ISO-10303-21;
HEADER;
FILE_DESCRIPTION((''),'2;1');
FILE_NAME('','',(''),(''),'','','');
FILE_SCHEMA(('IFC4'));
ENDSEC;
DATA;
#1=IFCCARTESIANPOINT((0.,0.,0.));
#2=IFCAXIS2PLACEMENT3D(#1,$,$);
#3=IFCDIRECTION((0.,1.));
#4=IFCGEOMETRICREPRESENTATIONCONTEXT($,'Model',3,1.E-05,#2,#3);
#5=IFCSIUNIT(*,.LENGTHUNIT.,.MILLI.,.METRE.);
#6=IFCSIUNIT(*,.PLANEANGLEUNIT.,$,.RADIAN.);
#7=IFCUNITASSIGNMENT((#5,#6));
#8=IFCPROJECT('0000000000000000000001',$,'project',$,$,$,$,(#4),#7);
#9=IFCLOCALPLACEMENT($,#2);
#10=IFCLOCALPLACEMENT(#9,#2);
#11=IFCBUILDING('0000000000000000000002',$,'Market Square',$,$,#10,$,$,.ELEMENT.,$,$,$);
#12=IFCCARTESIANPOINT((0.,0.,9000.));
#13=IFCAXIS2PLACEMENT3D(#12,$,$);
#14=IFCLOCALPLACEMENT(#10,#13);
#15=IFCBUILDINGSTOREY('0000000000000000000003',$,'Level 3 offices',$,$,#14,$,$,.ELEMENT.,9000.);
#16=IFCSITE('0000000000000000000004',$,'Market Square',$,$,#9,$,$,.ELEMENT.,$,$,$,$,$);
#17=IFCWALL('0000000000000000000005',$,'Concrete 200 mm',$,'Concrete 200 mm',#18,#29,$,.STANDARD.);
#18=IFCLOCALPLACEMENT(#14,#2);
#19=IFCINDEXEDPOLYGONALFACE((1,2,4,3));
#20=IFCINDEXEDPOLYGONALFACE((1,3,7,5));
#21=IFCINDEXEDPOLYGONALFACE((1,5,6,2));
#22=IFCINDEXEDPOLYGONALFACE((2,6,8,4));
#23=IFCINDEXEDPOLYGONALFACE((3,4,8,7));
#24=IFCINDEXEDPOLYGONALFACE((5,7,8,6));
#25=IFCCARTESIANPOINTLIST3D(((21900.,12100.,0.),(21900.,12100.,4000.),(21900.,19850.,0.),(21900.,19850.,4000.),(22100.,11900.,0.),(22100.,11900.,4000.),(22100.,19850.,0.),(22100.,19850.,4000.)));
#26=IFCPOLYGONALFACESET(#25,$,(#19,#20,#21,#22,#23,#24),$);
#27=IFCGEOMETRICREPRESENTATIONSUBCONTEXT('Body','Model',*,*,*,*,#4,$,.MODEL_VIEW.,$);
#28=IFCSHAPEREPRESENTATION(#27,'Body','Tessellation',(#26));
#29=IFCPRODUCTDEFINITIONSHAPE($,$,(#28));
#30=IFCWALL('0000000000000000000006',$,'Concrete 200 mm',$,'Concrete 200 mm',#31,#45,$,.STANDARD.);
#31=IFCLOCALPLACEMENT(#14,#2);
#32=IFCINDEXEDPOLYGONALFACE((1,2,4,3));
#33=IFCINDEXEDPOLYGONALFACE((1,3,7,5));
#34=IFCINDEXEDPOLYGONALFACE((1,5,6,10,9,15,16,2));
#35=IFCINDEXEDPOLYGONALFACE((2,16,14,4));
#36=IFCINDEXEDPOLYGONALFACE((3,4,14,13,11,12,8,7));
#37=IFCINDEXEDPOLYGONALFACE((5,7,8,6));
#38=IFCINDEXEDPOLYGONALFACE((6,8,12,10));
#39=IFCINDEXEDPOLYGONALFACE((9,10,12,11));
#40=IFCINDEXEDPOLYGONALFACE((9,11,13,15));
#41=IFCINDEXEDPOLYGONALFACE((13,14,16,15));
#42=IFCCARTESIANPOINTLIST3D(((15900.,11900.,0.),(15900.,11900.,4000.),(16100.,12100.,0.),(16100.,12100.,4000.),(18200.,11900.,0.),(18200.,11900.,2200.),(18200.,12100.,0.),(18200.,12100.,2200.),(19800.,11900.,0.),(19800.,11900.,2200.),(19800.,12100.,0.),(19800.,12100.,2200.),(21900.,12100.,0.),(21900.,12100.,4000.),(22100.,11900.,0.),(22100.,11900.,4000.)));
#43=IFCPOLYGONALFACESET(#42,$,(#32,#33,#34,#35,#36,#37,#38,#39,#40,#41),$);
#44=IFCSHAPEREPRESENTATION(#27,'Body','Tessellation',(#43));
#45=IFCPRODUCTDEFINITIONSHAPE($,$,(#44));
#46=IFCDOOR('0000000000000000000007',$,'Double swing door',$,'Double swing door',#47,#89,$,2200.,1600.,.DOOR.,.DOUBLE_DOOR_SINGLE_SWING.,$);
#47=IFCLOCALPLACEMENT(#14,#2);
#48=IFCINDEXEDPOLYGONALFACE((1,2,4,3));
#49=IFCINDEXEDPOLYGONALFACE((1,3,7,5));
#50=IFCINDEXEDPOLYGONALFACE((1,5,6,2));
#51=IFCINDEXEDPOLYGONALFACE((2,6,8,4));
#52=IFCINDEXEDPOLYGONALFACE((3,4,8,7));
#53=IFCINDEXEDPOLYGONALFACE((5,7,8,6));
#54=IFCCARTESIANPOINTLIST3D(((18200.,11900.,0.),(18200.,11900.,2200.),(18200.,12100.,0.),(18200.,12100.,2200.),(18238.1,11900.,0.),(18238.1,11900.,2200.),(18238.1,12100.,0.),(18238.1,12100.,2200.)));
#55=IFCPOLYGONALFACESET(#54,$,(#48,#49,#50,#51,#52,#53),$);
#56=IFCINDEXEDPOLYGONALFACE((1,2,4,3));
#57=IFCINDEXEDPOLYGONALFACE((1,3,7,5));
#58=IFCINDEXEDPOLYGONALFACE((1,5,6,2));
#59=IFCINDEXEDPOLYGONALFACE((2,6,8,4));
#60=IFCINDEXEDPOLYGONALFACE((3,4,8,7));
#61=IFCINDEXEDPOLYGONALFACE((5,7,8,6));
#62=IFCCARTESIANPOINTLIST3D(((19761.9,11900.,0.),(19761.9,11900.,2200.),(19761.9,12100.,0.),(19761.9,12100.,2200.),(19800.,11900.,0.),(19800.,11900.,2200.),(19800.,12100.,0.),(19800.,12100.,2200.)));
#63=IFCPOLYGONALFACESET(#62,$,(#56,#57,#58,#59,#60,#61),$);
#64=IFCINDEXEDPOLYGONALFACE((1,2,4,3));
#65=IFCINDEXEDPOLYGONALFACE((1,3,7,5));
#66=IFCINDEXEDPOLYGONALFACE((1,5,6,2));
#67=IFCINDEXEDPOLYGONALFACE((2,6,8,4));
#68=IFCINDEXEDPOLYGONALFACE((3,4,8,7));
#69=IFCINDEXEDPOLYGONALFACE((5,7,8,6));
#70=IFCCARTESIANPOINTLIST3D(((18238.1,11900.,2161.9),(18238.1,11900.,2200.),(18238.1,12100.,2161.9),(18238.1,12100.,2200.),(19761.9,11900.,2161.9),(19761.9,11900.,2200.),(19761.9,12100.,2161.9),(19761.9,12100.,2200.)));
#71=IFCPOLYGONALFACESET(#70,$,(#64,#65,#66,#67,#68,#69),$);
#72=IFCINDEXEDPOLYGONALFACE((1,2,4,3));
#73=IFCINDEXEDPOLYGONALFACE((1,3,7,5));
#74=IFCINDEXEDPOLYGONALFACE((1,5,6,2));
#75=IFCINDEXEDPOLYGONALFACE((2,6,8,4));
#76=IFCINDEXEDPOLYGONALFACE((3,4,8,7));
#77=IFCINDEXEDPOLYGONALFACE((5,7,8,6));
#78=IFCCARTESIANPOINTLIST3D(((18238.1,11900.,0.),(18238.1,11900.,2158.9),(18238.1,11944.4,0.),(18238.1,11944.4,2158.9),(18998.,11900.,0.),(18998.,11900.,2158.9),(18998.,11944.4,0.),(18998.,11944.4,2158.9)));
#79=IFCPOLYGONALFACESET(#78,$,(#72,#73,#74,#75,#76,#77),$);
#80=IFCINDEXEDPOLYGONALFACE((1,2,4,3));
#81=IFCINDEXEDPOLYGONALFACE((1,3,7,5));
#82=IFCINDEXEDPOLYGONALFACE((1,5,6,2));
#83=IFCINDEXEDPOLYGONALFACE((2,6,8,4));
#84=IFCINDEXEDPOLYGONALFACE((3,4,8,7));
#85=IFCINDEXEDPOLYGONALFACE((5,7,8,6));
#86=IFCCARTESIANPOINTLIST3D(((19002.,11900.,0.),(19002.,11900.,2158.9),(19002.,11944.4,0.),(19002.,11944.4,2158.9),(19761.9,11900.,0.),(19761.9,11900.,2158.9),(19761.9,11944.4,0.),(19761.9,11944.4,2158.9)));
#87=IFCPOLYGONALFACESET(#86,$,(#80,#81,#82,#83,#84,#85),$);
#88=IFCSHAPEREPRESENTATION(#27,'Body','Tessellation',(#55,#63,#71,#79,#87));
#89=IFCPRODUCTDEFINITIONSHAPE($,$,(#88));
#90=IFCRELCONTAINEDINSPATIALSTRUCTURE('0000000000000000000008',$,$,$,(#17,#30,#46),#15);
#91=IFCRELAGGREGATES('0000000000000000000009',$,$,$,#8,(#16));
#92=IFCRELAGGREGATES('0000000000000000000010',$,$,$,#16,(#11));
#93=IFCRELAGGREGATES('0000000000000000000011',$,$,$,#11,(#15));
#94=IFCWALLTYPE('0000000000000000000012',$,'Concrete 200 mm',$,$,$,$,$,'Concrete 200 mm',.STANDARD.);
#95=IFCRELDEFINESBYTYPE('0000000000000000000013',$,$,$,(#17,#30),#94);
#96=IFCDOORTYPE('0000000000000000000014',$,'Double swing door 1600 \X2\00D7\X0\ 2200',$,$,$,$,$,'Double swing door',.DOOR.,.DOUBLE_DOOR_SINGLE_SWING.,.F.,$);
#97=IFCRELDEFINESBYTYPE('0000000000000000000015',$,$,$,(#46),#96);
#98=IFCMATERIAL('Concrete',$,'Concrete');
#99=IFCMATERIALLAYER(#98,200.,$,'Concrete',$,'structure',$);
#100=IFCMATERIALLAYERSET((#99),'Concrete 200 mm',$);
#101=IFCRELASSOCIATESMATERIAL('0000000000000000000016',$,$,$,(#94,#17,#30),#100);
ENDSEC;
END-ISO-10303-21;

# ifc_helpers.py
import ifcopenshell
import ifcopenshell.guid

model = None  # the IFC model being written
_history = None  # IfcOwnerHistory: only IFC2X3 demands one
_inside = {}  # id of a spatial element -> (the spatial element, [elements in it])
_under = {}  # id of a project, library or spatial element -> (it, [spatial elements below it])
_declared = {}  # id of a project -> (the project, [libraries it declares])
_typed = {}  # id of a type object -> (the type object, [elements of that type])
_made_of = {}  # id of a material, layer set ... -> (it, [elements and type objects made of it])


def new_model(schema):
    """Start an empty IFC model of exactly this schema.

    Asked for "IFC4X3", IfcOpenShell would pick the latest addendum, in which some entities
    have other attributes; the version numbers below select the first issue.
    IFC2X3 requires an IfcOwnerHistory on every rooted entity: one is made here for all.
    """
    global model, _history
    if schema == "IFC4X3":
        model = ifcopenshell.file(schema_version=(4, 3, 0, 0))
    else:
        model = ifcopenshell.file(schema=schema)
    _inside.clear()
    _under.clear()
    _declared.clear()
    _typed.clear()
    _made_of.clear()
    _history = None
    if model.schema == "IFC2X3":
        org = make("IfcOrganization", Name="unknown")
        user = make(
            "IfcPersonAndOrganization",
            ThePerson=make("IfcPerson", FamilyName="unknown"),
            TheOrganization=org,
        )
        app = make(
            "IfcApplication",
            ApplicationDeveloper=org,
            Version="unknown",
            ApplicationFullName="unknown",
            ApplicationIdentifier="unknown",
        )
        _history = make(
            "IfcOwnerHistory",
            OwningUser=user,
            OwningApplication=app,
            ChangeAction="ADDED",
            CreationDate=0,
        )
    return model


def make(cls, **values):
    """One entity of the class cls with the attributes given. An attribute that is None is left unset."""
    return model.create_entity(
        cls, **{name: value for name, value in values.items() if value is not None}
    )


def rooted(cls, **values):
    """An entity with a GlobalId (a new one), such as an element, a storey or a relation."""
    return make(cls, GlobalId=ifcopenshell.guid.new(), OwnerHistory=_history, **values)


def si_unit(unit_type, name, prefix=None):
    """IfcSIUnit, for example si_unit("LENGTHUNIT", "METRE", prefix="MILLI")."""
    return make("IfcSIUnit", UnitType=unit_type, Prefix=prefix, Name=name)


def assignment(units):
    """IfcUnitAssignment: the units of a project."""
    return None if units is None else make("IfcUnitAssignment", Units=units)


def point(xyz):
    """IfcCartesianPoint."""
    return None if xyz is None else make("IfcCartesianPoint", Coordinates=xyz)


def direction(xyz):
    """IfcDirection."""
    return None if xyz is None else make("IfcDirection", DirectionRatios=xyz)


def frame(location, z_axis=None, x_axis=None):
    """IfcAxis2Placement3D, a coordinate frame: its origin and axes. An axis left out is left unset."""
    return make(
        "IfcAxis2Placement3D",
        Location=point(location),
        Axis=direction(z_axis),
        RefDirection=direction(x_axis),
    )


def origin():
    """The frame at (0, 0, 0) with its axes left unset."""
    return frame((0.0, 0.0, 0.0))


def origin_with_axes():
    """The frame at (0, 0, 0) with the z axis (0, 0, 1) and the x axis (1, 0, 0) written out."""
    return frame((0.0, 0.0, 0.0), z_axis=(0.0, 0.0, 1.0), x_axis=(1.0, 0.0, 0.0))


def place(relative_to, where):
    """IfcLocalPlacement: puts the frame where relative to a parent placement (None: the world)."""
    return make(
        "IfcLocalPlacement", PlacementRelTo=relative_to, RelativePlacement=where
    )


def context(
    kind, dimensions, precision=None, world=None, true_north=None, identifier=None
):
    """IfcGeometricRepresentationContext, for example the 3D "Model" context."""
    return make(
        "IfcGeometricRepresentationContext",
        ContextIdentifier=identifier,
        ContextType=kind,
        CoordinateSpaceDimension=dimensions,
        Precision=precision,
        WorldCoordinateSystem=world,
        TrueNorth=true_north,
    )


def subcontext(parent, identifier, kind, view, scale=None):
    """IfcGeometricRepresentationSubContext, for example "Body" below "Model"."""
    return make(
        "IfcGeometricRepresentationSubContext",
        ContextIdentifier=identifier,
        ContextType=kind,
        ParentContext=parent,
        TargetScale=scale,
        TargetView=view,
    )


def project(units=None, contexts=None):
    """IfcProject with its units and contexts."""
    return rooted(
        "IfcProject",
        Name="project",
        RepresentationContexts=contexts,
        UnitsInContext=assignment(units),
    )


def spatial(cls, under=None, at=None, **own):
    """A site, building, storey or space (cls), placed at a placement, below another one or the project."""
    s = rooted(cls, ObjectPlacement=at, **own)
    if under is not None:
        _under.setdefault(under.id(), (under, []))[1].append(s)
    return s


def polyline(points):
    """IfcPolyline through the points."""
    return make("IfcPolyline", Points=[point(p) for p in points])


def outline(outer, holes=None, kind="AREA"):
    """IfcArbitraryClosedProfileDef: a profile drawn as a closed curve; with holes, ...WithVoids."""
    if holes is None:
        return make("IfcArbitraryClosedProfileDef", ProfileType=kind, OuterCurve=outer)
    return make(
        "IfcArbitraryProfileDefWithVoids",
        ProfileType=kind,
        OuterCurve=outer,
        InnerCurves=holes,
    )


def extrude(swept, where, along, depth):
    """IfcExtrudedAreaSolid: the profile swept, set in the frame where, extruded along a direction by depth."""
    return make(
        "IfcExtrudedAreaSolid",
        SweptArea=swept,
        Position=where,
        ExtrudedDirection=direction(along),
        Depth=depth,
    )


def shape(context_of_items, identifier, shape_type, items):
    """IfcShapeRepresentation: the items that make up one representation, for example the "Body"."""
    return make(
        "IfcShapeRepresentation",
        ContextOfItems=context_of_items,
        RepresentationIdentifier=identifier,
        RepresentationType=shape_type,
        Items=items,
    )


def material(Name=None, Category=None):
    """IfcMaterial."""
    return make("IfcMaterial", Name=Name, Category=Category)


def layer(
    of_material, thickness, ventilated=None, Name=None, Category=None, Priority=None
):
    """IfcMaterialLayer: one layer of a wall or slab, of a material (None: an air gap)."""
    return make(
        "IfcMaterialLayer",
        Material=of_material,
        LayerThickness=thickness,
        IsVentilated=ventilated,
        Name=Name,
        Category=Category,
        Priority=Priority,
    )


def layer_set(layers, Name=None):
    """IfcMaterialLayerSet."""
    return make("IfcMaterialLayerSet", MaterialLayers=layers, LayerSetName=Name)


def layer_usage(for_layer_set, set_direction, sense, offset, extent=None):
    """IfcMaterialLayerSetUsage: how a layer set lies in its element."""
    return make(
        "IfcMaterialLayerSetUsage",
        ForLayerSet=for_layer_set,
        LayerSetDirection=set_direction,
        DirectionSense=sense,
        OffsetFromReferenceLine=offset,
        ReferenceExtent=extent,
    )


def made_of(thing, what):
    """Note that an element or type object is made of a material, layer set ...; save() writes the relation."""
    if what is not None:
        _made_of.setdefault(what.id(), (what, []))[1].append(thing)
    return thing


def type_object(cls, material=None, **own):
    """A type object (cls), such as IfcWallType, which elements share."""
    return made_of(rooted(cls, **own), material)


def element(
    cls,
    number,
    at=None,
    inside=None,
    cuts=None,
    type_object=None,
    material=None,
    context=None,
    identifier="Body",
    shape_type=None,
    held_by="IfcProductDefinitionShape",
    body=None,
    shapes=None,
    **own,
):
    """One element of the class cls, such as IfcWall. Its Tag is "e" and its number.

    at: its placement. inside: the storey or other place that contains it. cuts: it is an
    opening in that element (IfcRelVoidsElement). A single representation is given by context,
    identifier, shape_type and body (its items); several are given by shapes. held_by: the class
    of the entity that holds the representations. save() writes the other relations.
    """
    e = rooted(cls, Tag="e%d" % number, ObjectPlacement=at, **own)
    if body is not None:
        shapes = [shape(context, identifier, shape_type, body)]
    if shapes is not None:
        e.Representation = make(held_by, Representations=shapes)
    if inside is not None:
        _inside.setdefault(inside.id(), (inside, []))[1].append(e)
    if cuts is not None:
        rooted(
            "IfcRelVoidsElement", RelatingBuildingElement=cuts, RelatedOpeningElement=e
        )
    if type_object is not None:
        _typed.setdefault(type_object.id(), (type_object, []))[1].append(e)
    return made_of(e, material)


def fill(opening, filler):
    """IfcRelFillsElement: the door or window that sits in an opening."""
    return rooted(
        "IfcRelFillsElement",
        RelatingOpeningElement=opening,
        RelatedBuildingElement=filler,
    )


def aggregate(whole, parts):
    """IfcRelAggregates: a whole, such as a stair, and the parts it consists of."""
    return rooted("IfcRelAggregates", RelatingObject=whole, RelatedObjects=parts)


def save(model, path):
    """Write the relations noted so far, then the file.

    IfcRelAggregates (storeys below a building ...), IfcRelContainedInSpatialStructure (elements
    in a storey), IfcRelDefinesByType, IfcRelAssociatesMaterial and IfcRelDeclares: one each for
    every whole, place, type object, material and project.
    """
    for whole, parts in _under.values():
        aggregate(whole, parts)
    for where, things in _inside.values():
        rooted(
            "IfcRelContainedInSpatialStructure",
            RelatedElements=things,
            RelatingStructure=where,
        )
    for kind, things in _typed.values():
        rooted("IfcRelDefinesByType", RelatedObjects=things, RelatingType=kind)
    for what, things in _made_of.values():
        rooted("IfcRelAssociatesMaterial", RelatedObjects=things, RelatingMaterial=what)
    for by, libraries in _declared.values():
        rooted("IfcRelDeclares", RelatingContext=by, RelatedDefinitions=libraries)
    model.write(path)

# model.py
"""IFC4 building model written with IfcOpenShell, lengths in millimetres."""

from ifc_helpers import new_model, si_unit, direction, frame, origin, origin_with_axes, place, context, subcontext, project, spatial, polyline, outline, extrude, material, layer, layer_set, layer_usage, type_object, element, fill, save


model = new_model("IFC4")

# Units and contexts
model_context = context("Model", 3, precision=1e-05, world=origin(), true_north=direction((0.0, 1.0)))
body_context = subcontext(model_context, "Body", "Model", "MODEL_VIEW")
ifc_project = project(units=[si_unit("LENGTHUNIT", "METRE", prefix="MILLI"), si_unit("PLANEANGLEUNIT", "RADIAN")], contexts=[model_context])

# Site, building, storey
site_placement = place(None, origin())
site = spatial("IfcSite", under=ifc_project, at=site_placement, Name="Market Square", CompositionType="ELEMENT")
building_placement = place(site_placement, origin())
building = spatial("IfcBuilding", under=site, at=building_placement, Name="Market Square", CompositionType="ELEMENT")
storey_placement = place(building_placement, frame((0.0, 0.0, 9000.0)))
storey = spatial("IfcBuildingStorey", under=building, at=storey_placement, Name="Level 3 offices", CompositionType="ELEMENT", Elevation=9000.0)

# Wall
ifc_material_1 = material(Name="Concrete", Category="Concrete")
ifc_layer_1 = layer(ifc_material_1, 200.0, Name="Concrete", Category="structure")
ifc_layer_set_1 = layer_set([ifc_layer_1], Name="Concrete 200 mm")
ifc_layer_usage_1 = layer_usage(ifc_layer_set_1, "AXIS2", "NEGATIVE", 100.0)
wall_type_1 = type_object("IfcWallType", Name="Concrete 200 mm", ElementType="Concrete 200 mm", PredefinedType="STANDARD", material=ifc_layer_set_1)
wall_1_placement = place(storey_placement, frame((22000.0, 12000.0, 0.0), z_axis=(0.0, 0.0, 1.0), x_axis=(0.0, 1.0, 0.0)))
element("IfcWall", 1, at=wall_1_placement, inside=storey, type_object=wall_type_1, material=ifc_layer_usage_1, Name="Concrete 200 mm", ObjectType="Concrete 200 mm", PredefinedType="STANDARD", context=body_context, shape_type="SweptSolid", body=[
    extrude(outline(polyline([(-100.0, -100.0), (7850.0, -100.0), (7850.0, 100.0), (100.0, 100.0), (-100.0, -100.0)])), origin(), (0.0, 0.0, 1.0), 4000.0),
])

# Wall, opening, door
ifc_layer_usage_2 = layer_usage(ifc_layer_set_1, "AXIS2", "NEGATIVE", 100.0)
wall_2_placement = place(storey_placement, frame((16000.0, 12000.0, 0.0), z_axis=(0.0, 0.0, 1.0), x_axis=(1.0, 0.0, 0.0)))
wall_2 = element("IfcWall", 2, at=wall_2_placement, inside=storey, type_object=wall_type_1, material=ifc_layer_usage_2, Name="Concrete 200 mm", ObjectType="Concrete 200 mm", PredefinedType="STANDARD", context=body_context, shape_type="SweptSolid", body=[
    extrude(outline(polyline([(-100.0, -100.0), (6100.0, -100.0), (5900.0, 100.0), (100.0, 100.0), (-100.0, -100.0)])), origin(), (0.0, 0.0, 1.0), 4000.0),
])
opening_1_placement = place(wall_2_placement, frame((2200.0, 0.0, 0.0), z_axis=(0.0, 0.0, 1.0), x_axis=(1.0, 0.0, 0.0)))
opening_1 = element("IfcOpeningElement", 3, at=opening_1_placement, cuts=wall_2, PredefinedType="OPENING", context=body_context, shape_type="SweptSolid", body=[
    extrude(outline(polyline([(0.0, -110.0), (1600.0, -110.0), (1600.0, 110.0), (0.0, 110.0), (0.0, -110.0)])), origin(), (0.0, 0.0, 1.0), 2200.0),
])
door_type = type_object("IfcDoorType", Name="Double swing door 1600 × 2200", ElementType="Double swing door", OperationType="DOUBLE_DOOR_SINGLE_SWING", ParameterTakesPrecedence=False, PredefinedType="DOOR")
door_placement = place(opening_1_placement, origin_with_axes())
door = element("IfcDoor", 4, at=door_placement, inside=storey, type_object=door_type, Name="Double swing door", ObjectType="Double swing door", OperationType="DOUBLE_DOOR_SINGLE_SWING", OverallHeight=2200.0, OverallWidth=1600.0, PredefinedType="DOOR", context=body_context, shape_type="SweptSolid", body=[
    extrude(outline(polyline([(0.0, -100.0), (38.1, -100.0), (38.1, 100.0), (0.0, 100.0), (0.0, -100.0)])), origin(), (0.0, 0.0, 1.0), 2200.0),
    extrude(outline(polyline([(1561.9, -100.0), (1600.0, -100.0), (1600.0, 100.0), (1561.9, 100.0), (1561.9, -100.0)])), origin(), (0.0, 0.0, 1.0), 2200.0),
    extrude(outline(polyline([(38.1, -100.0), (1561.9, -100.0), (1561.9, 100.0), (38.1, 100.0), (38.1, -100.0)])), frame((0.0, 0.0, 2161.9)), (0.0, 0.0, 1.0), 38.1),
    extrude(outline(polyline([(38.1, -100.0), (798.0, -100.0), (798.0, -55.5), (38.1, -55.5), (38.1, -100.0)])), origin(), (0.0, 0.0, 1.0), 2158.9),
    extrude(outline(polyline([(802.0, -100.0), (1561.9, -100.0), (1561.9, -55.5), (802.0, -55.5), (802.0, -100.0)])), origin(), (0.0, 0.0, 1.0), 2158.9),
])
fill(opening_1, door)

save(model, "model.ifc")
